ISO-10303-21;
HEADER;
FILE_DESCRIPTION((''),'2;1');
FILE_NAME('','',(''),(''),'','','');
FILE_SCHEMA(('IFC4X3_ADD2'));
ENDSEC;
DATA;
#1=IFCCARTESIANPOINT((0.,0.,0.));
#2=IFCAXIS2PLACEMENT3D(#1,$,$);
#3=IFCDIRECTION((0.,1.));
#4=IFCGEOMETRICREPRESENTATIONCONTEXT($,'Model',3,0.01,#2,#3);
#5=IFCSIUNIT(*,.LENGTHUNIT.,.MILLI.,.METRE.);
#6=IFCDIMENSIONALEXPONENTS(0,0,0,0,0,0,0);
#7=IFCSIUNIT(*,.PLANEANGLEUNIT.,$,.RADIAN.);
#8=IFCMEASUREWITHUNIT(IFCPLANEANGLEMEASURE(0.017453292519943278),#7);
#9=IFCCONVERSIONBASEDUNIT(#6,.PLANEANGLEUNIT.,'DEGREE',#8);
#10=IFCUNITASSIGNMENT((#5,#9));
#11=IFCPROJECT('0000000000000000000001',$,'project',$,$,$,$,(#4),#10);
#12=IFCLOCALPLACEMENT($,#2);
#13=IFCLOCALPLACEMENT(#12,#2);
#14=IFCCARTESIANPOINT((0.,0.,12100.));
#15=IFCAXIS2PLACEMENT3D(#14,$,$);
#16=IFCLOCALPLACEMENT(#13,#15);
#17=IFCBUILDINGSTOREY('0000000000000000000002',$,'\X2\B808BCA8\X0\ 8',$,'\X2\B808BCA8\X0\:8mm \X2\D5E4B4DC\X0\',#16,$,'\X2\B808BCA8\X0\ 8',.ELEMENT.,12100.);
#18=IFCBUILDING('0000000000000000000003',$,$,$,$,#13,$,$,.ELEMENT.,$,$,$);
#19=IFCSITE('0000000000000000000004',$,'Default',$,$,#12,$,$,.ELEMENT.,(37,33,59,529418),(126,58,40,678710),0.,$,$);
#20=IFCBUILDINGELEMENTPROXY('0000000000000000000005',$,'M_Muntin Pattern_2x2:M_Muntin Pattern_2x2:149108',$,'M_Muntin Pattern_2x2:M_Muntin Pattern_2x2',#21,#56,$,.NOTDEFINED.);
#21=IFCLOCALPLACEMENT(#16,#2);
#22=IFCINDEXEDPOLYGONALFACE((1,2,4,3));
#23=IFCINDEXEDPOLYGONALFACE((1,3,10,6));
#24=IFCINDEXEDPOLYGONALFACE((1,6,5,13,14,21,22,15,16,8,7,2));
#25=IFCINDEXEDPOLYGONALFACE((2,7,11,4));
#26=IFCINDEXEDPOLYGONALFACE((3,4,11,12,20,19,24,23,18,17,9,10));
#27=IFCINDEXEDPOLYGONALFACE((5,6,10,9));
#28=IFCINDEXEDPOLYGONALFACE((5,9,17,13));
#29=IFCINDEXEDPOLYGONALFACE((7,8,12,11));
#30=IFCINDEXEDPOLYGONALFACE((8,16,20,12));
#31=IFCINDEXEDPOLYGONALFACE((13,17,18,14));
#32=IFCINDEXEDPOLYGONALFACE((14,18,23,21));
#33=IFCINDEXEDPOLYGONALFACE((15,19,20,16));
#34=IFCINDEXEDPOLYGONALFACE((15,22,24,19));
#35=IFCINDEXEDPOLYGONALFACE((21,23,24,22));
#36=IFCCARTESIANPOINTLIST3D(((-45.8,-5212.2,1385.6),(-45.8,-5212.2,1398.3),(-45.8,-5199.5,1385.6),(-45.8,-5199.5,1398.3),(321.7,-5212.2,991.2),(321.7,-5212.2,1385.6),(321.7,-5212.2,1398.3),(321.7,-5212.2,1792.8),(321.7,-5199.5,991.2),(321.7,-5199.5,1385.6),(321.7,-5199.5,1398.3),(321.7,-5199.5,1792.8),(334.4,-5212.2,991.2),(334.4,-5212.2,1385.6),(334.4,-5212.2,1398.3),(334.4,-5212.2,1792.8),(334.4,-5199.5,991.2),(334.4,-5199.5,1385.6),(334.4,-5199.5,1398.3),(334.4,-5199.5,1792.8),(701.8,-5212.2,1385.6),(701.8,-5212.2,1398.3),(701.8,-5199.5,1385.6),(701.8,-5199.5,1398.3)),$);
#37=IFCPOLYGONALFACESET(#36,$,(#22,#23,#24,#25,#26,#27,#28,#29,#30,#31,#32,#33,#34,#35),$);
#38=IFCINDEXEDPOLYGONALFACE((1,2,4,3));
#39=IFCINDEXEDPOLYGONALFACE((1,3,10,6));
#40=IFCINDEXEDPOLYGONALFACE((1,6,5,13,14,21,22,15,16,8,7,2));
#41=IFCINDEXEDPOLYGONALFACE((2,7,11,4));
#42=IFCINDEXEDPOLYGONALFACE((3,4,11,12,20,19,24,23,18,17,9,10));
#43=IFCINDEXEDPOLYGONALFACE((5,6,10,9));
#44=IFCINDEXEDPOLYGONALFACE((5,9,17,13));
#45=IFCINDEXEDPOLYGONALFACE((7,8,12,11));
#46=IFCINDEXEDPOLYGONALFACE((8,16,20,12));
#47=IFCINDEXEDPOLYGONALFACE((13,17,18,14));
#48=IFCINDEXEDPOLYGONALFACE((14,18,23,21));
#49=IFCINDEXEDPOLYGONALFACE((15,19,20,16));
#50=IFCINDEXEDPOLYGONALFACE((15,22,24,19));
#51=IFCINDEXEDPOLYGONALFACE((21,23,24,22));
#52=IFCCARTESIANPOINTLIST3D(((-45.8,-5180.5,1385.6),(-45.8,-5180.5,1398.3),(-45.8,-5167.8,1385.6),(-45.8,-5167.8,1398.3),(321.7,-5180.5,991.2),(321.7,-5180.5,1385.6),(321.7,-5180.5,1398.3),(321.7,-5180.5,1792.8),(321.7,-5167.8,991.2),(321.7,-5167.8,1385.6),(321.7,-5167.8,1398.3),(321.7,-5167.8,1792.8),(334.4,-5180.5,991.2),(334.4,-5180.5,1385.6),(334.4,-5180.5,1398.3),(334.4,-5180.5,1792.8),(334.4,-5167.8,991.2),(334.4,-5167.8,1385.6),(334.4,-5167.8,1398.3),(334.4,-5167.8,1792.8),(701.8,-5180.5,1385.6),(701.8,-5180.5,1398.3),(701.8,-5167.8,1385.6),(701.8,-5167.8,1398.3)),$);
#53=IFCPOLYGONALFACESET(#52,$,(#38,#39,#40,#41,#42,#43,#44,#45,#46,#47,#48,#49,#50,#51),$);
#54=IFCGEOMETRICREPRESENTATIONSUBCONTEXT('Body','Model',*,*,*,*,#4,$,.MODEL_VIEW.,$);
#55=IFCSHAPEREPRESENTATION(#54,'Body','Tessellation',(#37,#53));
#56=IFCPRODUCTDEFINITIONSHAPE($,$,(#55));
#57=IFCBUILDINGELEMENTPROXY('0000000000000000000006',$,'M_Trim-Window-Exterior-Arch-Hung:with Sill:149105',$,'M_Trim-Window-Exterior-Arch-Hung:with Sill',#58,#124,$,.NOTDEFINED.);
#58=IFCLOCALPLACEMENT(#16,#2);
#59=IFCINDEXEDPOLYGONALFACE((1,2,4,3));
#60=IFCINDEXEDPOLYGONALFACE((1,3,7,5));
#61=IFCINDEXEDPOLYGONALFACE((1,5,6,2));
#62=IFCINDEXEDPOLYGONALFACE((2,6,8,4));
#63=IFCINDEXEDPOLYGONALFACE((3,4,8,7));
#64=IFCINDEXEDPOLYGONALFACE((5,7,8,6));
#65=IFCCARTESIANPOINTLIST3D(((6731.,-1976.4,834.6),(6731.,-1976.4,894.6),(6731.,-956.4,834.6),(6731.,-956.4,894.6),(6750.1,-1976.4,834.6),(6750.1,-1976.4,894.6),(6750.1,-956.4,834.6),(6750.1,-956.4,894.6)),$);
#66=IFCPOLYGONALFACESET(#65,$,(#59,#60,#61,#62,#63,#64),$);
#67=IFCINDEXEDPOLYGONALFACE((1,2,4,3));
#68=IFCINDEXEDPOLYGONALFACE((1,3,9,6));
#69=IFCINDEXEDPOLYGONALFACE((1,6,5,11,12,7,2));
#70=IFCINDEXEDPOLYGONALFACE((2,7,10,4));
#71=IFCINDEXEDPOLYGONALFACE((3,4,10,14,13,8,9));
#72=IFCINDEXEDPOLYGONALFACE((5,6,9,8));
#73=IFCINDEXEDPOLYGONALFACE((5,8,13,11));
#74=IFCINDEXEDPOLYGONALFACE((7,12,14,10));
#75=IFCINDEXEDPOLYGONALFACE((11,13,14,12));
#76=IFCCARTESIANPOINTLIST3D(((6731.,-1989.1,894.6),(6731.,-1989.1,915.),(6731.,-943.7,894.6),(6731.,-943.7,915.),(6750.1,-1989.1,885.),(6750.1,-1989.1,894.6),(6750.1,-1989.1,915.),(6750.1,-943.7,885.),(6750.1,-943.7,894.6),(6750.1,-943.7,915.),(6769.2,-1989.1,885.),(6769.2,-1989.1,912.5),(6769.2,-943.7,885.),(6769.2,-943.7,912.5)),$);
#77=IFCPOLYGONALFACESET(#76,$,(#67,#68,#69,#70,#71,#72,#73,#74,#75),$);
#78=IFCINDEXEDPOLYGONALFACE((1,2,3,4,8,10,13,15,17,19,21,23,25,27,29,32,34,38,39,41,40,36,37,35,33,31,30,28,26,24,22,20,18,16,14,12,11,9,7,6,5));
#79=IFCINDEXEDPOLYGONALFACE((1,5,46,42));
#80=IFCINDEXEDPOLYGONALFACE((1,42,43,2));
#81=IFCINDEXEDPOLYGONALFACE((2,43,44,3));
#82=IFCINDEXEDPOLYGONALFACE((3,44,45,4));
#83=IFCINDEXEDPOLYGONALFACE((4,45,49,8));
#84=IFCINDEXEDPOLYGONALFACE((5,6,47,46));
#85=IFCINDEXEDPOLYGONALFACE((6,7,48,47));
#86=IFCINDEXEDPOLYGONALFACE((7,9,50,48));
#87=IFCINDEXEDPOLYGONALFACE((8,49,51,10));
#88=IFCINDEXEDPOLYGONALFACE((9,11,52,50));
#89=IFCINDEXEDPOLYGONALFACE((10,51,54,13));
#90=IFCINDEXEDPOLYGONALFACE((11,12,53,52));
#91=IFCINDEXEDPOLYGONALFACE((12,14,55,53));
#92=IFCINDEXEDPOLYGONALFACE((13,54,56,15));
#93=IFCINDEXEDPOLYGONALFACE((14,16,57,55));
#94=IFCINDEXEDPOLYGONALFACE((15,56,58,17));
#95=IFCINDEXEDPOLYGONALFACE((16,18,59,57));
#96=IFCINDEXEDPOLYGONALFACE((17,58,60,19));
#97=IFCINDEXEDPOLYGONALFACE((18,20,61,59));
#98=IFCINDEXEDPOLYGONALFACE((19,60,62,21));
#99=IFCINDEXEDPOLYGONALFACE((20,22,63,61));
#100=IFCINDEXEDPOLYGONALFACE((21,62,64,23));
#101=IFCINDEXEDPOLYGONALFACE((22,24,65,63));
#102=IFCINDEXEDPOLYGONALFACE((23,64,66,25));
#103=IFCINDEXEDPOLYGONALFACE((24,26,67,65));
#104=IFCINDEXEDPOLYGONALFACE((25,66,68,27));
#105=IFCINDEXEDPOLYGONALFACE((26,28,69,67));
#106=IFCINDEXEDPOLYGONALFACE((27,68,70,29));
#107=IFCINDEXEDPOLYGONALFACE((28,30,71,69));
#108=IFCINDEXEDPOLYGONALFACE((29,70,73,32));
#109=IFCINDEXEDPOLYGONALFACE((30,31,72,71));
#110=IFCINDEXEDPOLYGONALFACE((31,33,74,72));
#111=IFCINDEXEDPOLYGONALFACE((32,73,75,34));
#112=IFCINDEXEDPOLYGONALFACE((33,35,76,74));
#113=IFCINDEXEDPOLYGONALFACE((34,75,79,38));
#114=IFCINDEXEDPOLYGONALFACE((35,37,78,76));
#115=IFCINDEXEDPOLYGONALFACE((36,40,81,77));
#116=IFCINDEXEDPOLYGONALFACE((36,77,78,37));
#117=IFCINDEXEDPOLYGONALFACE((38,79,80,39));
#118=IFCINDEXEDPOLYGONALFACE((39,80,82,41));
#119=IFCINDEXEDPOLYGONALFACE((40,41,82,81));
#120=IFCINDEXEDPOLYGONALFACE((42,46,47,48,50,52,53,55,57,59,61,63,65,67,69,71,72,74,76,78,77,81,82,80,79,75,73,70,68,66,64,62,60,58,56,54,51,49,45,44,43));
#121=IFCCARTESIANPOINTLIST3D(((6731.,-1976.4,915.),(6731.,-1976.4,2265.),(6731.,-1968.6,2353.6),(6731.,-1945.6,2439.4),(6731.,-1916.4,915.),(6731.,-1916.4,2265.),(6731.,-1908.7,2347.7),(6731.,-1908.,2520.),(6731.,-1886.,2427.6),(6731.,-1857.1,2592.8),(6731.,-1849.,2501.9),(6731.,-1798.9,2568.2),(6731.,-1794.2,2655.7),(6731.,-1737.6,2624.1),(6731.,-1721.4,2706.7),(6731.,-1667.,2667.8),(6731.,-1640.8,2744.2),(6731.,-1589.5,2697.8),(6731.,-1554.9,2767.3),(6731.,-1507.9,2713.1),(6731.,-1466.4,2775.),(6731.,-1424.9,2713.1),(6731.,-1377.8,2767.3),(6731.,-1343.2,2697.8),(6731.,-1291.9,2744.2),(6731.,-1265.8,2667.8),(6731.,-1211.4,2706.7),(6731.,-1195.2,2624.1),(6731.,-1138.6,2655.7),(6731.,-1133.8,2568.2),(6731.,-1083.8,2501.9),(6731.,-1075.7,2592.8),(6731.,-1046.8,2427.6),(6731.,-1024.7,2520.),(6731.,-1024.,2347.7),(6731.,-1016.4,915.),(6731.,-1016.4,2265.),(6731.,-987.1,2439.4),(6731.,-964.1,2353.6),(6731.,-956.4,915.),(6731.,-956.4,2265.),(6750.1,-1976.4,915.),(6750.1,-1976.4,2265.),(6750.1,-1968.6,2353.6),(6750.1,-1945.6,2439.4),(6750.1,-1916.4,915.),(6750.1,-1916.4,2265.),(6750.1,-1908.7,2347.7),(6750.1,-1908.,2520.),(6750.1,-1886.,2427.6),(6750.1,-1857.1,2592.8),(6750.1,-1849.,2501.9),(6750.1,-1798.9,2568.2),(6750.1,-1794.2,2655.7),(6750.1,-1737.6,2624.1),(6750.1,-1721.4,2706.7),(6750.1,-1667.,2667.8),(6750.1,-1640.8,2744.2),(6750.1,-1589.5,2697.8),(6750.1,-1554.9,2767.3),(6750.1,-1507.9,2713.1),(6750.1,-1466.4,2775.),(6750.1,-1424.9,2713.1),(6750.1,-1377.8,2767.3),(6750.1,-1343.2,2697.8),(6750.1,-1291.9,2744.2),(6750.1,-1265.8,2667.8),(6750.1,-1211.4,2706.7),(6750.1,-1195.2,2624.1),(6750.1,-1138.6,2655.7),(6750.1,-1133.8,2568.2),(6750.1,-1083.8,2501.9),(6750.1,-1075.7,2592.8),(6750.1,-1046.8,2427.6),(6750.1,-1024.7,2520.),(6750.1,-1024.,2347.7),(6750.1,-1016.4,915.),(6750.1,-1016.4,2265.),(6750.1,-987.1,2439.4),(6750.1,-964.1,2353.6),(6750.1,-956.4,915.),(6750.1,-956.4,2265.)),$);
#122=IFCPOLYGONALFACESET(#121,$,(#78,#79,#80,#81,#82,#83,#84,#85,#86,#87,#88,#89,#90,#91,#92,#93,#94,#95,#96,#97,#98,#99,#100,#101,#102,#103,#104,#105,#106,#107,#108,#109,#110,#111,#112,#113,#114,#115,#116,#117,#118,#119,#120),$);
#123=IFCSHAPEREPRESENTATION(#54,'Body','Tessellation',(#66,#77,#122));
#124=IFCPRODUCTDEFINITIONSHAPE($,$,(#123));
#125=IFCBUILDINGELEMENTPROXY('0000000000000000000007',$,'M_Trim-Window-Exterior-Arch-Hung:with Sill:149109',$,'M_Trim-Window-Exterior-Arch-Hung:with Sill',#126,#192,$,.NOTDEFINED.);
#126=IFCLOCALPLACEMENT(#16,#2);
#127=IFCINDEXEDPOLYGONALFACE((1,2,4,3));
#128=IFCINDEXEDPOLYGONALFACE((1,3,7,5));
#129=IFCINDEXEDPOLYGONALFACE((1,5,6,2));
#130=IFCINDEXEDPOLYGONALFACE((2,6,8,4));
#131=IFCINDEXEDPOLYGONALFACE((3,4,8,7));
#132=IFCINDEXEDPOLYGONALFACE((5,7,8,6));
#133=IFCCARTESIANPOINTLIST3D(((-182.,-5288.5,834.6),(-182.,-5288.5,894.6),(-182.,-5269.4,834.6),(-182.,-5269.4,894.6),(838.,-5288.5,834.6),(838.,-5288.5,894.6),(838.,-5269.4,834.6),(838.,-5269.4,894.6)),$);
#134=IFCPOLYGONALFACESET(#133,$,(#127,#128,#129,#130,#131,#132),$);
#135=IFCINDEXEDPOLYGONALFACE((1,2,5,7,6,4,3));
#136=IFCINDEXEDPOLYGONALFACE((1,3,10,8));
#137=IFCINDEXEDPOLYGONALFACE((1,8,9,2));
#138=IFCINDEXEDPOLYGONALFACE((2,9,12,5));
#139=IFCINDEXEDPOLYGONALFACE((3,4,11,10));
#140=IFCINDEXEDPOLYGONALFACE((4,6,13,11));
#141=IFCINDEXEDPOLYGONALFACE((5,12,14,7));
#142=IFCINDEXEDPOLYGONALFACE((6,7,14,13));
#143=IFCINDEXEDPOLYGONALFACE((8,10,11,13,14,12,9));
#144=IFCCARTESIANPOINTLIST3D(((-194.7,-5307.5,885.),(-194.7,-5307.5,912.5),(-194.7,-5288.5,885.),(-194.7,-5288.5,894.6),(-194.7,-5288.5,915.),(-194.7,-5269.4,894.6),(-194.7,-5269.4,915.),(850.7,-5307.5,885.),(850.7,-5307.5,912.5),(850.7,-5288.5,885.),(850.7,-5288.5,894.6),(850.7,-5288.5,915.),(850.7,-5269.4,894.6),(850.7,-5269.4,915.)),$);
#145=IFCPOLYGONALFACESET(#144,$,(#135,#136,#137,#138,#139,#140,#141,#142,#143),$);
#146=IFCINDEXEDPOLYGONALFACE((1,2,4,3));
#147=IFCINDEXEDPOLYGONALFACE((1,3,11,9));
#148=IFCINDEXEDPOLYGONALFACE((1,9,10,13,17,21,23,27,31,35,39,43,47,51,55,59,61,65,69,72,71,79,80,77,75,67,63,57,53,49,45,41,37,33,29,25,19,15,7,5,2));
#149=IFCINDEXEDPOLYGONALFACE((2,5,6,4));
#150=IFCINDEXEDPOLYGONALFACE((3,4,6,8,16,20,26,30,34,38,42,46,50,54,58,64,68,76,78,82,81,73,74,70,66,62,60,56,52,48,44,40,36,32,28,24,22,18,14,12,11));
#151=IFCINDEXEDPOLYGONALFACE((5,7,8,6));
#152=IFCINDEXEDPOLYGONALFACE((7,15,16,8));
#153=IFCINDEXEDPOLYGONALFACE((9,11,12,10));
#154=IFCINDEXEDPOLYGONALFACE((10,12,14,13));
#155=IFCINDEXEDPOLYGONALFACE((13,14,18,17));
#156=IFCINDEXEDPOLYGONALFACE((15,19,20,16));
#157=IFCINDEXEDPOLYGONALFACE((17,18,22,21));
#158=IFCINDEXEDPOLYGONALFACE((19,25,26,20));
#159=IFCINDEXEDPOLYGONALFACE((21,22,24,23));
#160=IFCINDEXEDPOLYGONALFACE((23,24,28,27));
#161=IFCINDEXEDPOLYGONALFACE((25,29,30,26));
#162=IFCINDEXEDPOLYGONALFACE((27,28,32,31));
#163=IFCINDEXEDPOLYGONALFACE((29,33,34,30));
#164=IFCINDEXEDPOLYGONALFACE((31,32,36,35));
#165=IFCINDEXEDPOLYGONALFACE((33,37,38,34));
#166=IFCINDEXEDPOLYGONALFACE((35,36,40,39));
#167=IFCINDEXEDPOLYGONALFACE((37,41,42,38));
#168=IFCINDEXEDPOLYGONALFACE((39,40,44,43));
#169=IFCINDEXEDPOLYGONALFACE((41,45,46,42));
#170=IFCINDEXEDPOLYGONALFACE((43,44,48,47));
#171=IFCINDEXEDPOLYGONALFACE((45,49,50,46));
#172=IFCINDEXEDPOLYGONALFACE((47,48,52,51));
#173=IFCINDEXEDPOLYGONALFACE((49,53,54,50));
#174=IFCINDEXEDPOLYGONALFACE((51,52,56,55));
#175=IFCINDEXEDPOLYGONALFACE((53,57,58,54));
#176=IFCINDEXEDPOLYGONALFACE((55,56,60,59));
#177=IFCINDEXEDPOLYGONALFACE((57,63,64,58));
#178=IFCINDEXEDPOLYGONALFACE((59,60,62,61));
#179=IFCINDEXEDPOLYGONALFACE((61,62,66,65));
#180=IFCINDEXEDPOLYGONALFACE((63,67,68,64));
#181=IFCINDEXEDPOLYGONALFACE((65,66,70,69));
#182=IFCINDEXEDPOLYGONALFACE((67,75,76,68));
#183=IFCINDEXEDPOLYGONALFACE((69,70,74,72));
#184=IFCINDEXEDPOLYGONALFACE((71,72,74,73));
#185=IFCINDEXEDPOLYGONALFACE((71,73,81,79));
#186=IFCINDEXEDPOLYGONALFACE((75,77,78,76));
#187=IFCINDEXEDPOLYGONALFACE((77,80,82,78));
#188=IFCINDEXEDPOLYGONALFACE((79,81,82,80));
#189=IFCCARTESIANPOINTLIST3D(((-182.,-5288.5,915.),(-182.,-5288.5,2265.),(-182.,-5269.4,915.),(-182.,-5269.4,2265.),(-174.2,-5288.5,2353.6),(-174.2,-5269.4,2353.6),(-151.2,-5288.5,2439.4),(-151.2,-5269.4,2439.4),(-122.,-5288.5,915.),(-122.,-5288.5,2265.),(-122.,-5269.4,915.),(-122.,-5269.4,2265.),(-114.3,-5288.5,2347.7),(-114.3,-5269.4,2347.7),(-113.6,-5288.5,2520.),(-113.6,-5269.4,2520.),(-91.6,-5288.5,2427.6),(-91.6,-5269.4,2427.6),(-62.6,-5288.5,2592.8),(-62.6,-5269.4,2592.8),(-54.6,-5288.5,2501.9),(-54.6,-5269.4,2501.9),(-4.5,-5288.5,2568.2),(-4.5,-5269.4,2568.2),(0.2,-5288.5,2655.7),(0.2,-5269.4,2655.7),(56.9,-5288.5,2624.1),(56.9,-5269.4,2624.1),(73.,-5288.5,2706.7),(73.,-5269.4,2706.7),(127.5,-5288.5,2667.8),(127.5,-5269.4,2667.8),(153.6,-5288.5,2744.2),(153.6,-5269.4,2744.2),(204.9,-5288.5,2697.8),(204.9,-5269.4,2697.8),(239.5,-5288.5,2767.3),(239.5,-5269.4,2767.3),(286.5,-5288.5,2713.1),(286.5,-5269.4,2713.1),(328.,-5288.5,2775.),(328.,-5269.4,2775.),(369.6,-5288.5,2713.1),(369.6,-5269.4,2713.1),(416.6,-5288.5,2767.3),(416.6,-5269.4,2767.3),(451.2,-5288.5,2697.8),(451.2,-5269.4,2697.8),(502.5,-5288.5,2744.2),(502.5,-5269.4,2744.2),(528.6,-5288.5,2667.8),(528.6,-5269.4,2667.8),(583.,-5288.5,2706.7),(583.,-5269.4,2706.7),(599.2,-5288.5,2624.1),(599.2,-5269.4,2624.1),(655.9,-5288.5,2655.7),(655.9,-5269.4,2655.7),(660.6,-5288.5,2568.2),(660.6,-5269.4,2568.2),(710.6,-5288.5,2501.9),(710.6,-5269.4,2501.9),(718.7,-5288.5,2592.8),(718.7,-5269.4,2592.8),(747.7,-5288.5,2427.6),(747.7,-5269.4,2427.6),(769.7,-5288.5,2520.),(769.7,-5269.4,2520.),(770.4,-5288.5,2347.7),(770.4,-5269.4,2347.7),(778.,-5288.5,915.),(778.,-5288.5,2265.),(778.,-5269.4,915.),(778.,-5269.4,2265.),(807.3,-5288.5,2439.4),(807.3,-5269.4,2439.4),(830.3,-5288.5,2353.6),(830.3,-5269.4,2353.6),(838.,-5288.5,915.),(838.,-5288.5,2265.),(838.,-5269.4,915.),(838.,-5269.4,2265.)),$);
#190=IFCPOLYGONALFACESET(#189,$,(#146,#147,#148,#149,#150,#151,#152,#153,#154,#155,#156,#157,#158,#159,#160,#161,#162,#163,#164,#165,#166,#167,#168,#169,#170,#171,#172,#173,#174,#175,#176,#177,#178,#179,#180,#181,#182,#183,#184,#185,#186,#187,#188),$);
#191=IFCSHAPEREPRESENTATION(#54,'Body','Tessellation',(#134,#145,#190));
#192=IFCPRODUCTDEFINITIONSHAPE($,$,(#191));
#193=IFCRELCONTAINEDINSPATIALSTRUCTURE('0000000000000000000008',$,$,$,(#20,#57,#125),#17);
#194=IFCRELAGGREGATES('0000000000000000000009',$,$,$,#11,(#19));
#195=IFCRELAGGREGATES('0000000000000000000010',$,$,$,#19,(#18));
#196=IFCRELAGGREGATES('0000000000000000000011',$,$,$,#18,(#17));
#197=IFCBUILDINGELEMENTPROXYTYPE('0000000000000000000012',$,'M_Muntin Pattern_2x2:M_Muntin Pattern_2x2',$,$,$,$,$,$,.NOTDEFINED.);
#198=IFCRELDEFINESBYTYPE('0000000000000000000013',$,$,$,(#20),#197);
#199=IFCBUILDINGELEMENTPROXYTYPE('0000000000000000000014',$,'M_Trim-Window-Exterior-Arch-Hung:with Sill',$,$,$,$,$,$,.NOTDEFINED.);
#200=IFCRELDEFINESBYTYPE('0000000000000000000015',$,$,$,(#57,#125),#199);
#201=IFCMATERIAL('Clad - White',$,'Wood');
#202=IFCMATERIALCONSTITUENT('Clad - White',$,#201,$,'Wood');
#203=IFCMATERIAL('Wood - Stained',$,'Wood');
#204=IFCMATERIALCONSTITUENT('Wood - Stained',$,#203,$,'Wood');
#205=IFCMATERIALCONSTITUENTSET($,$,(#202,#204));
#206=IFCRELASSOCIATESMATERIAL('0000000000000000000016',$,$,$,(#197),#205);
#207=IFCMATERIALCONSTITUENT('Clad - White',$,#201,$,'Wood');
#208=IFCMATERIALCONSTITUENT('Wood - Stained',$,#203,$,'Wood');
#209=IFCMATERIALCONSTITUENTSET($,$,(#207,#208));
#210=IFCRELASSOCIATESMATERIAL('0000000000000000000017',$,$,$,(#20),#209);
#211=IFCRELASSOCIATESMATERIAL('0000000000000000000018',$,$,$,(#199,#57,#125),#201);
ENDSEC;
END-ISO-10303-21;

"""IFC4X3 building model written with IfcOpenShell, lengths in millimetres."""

from ifc_helpers import new_model, entity, si_unit, converted_unit, direction, frame, frame_2d, origin, place, context, subcontext, project, spatial, polyline, circle_curve, parameter, trimmed, segment, composite_curve, rectangle, outline, extrude, source, transform, mapped, material, constituent, constituent_set, type_object, type_shapes, element, save


model = new_model("IFC4X3")

# Units and contexts
model_context = context("Model", 3, precision=0.01, world=origin(), true_north=direction((0.0, 1.0)))
body_context = subcontext(model_context, "Body", "Model", "MODEL_VIEW")
ifc_project = project(units=[si_unit("LENGTHUNIT", "METRE", prefix="MILLI"), converted_unit("PLANEANGLEUNIT", "DEGREE", entity("IfcPlaneAngleMeasure", 0.017453292519943278), si_unit("PLANEANGLEUNIT", "RADIAN"), dimensions=[0, 0, 0, 0, 0, 0, 0])], contexts=[model_context])

# Site, building, storey
site_placement = place(None, origin())
site = spatial("IfcSite", under=ifc_project, at=site_placement, Name="Default", CompositionType="ELEMENT", RefLatitude=(37, 33, 59, 529418), RefLongitude=(126, 58, 40, 678710), RefElevation=0.0)
building_placement = place(site_placement, origin())
building = spatial("IfcBuilding", under=site, at=building_placement, CompositionType="ELEMENT")
storey_placement = place(building_placement, frame((0.0, 0.0, 12100.0)))
storey = spatial("IfcBuildingStorey", under=building, at=storey_placement, Name="레벨 8", ObjectType="레벨:8mm 헤드", LongName="레벨 8", CompositionType="ELEMENT", Elevation=12100.0)

# Building element proxies
ifc_material_1 = material(Name="Clad - White", Category="Wood")
ifc_material_2 = material(Name="Wood - Stained", Category="Wood")
ifc_constituent_1 = constituent(ifc_material_1, Name="Clad - White", Category="Wood")
ifc_constituent_2 = constituent(ifc_material_2, Name="Wood - Stained", Category="Wood")
ifc_constituent_set_1 = constituent_set(constituents=[ifc_constituent_1, ifc_constituent_2])
building_element_proxy_type_1 = type_object("IfcBuildingElementProxyType", Name="M_Muntin Pattern_2x2:M_Muntin Pattern_2x2", PredefinedType="NOTDEFINED", material=ifc_constituent_set_1)
shared_shape_1 = source(origin(), body_context, "Body", "SweptSolid", [
    extrude(outline(polyline([(6.4, -6.4), (400.8, -6.4), (400.8, 6.3), (6.4, 6.3), (6.4, 373.8), (-6.3, 373.8), (-6.3, 6.3), (-400.8, 6.3), (-400.8, -6.4), (-6.3, -6.4), (-6.3, -373.8), (6.4, -373.8), (6.4, -6.4)])), frame((0.0, 9.5, 400.8), z_axis=(0.0, 1.0, 0.0), x_axis=(0.0, 0.0, 1.0)), (0.0, 0.0, 1.0), 12.7),
    extrude(outline(polyline([(6.4, -6.4), (400.8, -6.4), (400.8, 6.3), (6.4, 6.3), (6.4, 373.8), (-6.3, 373.8), (-6.3, 6.3), (-400.8, 6.3), (-400.8, -6.4), (-6.3, -6.4), (-6.3, -373.8), (6.4, -373.8), (6.4, -6.4)])), frame((0.0, -22.2, 400.8), z_axis=(0.0, 1.0, 0.0), x_axis=(0.0, 0.0, 1.0)), (0.0, 0.0, 1.0), 12.7),
])
type_shapes(building_element_proxy_type_1, [shared_shape_1])
ifc_constituent_3 = constituent(ifc_material_1, Name="Clad - White", Category="Wood")
ifc_constituent_4 = constituent(ifc_material_2, Name="Wood - Stained", Category="Wood")
ifc_constituent_set_2 = constituent_set(constituents=[ifc_constituent_3, ifc_constituent_4])
proxy_1_placement = place(storey_placement, frame((328.0, -5190.0, 991.2), z_axis=(0.0, 0.0, 1.0), x_axis=(-1.0, 0.0, 0.0)))
element("IfcBuildingElementProxy", 1, at=proxy_1_placement, inside=storey, type_object=building_element_proxy_type_1, material=ifc_constituent_set_2, Name="M_Muntin Pattern_2x2:M_Muntin Pattern_2x2:149108", ObjectType="M_Muntin Pattern_2x2:M_Muntin Pattern_2x2", PredefinedType="NOTDEFINED", context=body_context, shape_type="MappedRepresentation", body=[
    mapped(shared_shape_1, transform((0.0, 0.0, 0.0), scale=1.0)),
])
building_element_proxy_type_2 = type_object("IfcBuildingElementProxyType", Name="M_Trim-Window-Exterior-Arch-Hung:with Sill", PredefinedType="NOTDEFINED", material=ifc_material_1)
shared_shape_2 = source(origin(), body_context, "Body", "SweptSolid", [
    extrude(rectangle(XDim=1020.0, YDim=60.0, at=frame_2d((0.0, 0.0), x_axis=(1.0, 0.0))), frame((0.0, -1850.4, 0.0), z_axis=(0.0, 0.0, 1.0), x_axis=(-1.0, 0.0, 0.0)), (0.0, 0.0, 1.0), 19.1),
    extrude(outline(polyline([(-19.1, -15.2), (0.0, -15.2), (0.0, -5.7), (19.1, -5.7), (19.1, 14.8), (0.0, 14.8), (-19.1, 12.3), (-19.1, -15.2)])), frame((-522.7, -1814.8, 19.1), z_axis=(1.0, 0.0, 0.0), x_axis=(0.0, 0.0, -1.0)), (0.0, 0.0, 1.0), 1045.4),
    extrude(outline(composite_curve([segment(polyline([(-675.0, -510.0), (675.0, -510.0)]), True, "CONTINUOUS"), segment(polyline([(675.0, -510.0), (675.0, -450.0)]), True, "CONTINUOUS"), segment(polyline([(675.0, -450.0), (-675.0, -450.0)]), True, "CONTINUOUS"), segment(trimmed(circle_curve(frame_2d((-675.0, 0.0), x_axis=(0.0, 1.0)), 450.0), [parameter(0.0)], [parameter(180.0)], True, "PARAMETER"), False, "CONTINUOUS"), segment(polyline([(-675.0, 450.0), (675.0, 450.0)]), True, "CONTINUOUS"), segment(polyline([(675.0, 450.0), (675.0, 510.0)]), True, "CONTINUOUS"), segment(polyline([(675.0, 510.0), (-675.0, 510.0)]), True, "CONTINUOUS"), segment(trimmed(circle_curve(frame_2d((-675.0, 0.0), x_axis=(0.0, 1.0)), 510.0), [parameter(0.0)], [parameter(180.0)], True, "PARAMETER"), True, "CONTINUOUS")], self_intersect=False)), frame((0.0, -1125.0, 0.0), z_axis=(0.0, 0.0, 1.0), x_axis=(0.0, -1.0, 0.0)), (0.0, 0.0, 1.0), 19.1),
])
type_shapes(building_element_proxy_type_2, [shared_shape_2])
for number, where, z_axis, x_axis, name in (
    (2, (6731.0, -1466.4, 2715.0), (1.0, 0.0, 0.0), (0.0, 1.0, 0.0), "M_Trim-Window-Exterior-Arch-Hung:with Sill:149105"),
    (3, (328.0, -5269.4, 2715.0), (0.0, -1.0, 0.0), (1.0, 0.0, 0.0), "M_Trim-Window-Exterior-Arch-Hung:with Sill:149109"),
):
    element("IfcBuildingElementProxy", number, at=place(storey_placement, frame(where, z_axis=z_axis, x_axis=x_axis)), inside=storey, type_object=building_element_proxy_type_2, material=ifc_material_1, Name=name, ObjectType="M_Trim-Window-Exterior-Arch-Hung:with Sill", PredefinedType="NOTDEFINED", context=body_context, shape_type="MappedRepresentation", body=[
        mapped(shared_shape_2, transform((0.0, 0.0, 0.0), scale=1.0)),
    ])

save(model, "model.ifc")
